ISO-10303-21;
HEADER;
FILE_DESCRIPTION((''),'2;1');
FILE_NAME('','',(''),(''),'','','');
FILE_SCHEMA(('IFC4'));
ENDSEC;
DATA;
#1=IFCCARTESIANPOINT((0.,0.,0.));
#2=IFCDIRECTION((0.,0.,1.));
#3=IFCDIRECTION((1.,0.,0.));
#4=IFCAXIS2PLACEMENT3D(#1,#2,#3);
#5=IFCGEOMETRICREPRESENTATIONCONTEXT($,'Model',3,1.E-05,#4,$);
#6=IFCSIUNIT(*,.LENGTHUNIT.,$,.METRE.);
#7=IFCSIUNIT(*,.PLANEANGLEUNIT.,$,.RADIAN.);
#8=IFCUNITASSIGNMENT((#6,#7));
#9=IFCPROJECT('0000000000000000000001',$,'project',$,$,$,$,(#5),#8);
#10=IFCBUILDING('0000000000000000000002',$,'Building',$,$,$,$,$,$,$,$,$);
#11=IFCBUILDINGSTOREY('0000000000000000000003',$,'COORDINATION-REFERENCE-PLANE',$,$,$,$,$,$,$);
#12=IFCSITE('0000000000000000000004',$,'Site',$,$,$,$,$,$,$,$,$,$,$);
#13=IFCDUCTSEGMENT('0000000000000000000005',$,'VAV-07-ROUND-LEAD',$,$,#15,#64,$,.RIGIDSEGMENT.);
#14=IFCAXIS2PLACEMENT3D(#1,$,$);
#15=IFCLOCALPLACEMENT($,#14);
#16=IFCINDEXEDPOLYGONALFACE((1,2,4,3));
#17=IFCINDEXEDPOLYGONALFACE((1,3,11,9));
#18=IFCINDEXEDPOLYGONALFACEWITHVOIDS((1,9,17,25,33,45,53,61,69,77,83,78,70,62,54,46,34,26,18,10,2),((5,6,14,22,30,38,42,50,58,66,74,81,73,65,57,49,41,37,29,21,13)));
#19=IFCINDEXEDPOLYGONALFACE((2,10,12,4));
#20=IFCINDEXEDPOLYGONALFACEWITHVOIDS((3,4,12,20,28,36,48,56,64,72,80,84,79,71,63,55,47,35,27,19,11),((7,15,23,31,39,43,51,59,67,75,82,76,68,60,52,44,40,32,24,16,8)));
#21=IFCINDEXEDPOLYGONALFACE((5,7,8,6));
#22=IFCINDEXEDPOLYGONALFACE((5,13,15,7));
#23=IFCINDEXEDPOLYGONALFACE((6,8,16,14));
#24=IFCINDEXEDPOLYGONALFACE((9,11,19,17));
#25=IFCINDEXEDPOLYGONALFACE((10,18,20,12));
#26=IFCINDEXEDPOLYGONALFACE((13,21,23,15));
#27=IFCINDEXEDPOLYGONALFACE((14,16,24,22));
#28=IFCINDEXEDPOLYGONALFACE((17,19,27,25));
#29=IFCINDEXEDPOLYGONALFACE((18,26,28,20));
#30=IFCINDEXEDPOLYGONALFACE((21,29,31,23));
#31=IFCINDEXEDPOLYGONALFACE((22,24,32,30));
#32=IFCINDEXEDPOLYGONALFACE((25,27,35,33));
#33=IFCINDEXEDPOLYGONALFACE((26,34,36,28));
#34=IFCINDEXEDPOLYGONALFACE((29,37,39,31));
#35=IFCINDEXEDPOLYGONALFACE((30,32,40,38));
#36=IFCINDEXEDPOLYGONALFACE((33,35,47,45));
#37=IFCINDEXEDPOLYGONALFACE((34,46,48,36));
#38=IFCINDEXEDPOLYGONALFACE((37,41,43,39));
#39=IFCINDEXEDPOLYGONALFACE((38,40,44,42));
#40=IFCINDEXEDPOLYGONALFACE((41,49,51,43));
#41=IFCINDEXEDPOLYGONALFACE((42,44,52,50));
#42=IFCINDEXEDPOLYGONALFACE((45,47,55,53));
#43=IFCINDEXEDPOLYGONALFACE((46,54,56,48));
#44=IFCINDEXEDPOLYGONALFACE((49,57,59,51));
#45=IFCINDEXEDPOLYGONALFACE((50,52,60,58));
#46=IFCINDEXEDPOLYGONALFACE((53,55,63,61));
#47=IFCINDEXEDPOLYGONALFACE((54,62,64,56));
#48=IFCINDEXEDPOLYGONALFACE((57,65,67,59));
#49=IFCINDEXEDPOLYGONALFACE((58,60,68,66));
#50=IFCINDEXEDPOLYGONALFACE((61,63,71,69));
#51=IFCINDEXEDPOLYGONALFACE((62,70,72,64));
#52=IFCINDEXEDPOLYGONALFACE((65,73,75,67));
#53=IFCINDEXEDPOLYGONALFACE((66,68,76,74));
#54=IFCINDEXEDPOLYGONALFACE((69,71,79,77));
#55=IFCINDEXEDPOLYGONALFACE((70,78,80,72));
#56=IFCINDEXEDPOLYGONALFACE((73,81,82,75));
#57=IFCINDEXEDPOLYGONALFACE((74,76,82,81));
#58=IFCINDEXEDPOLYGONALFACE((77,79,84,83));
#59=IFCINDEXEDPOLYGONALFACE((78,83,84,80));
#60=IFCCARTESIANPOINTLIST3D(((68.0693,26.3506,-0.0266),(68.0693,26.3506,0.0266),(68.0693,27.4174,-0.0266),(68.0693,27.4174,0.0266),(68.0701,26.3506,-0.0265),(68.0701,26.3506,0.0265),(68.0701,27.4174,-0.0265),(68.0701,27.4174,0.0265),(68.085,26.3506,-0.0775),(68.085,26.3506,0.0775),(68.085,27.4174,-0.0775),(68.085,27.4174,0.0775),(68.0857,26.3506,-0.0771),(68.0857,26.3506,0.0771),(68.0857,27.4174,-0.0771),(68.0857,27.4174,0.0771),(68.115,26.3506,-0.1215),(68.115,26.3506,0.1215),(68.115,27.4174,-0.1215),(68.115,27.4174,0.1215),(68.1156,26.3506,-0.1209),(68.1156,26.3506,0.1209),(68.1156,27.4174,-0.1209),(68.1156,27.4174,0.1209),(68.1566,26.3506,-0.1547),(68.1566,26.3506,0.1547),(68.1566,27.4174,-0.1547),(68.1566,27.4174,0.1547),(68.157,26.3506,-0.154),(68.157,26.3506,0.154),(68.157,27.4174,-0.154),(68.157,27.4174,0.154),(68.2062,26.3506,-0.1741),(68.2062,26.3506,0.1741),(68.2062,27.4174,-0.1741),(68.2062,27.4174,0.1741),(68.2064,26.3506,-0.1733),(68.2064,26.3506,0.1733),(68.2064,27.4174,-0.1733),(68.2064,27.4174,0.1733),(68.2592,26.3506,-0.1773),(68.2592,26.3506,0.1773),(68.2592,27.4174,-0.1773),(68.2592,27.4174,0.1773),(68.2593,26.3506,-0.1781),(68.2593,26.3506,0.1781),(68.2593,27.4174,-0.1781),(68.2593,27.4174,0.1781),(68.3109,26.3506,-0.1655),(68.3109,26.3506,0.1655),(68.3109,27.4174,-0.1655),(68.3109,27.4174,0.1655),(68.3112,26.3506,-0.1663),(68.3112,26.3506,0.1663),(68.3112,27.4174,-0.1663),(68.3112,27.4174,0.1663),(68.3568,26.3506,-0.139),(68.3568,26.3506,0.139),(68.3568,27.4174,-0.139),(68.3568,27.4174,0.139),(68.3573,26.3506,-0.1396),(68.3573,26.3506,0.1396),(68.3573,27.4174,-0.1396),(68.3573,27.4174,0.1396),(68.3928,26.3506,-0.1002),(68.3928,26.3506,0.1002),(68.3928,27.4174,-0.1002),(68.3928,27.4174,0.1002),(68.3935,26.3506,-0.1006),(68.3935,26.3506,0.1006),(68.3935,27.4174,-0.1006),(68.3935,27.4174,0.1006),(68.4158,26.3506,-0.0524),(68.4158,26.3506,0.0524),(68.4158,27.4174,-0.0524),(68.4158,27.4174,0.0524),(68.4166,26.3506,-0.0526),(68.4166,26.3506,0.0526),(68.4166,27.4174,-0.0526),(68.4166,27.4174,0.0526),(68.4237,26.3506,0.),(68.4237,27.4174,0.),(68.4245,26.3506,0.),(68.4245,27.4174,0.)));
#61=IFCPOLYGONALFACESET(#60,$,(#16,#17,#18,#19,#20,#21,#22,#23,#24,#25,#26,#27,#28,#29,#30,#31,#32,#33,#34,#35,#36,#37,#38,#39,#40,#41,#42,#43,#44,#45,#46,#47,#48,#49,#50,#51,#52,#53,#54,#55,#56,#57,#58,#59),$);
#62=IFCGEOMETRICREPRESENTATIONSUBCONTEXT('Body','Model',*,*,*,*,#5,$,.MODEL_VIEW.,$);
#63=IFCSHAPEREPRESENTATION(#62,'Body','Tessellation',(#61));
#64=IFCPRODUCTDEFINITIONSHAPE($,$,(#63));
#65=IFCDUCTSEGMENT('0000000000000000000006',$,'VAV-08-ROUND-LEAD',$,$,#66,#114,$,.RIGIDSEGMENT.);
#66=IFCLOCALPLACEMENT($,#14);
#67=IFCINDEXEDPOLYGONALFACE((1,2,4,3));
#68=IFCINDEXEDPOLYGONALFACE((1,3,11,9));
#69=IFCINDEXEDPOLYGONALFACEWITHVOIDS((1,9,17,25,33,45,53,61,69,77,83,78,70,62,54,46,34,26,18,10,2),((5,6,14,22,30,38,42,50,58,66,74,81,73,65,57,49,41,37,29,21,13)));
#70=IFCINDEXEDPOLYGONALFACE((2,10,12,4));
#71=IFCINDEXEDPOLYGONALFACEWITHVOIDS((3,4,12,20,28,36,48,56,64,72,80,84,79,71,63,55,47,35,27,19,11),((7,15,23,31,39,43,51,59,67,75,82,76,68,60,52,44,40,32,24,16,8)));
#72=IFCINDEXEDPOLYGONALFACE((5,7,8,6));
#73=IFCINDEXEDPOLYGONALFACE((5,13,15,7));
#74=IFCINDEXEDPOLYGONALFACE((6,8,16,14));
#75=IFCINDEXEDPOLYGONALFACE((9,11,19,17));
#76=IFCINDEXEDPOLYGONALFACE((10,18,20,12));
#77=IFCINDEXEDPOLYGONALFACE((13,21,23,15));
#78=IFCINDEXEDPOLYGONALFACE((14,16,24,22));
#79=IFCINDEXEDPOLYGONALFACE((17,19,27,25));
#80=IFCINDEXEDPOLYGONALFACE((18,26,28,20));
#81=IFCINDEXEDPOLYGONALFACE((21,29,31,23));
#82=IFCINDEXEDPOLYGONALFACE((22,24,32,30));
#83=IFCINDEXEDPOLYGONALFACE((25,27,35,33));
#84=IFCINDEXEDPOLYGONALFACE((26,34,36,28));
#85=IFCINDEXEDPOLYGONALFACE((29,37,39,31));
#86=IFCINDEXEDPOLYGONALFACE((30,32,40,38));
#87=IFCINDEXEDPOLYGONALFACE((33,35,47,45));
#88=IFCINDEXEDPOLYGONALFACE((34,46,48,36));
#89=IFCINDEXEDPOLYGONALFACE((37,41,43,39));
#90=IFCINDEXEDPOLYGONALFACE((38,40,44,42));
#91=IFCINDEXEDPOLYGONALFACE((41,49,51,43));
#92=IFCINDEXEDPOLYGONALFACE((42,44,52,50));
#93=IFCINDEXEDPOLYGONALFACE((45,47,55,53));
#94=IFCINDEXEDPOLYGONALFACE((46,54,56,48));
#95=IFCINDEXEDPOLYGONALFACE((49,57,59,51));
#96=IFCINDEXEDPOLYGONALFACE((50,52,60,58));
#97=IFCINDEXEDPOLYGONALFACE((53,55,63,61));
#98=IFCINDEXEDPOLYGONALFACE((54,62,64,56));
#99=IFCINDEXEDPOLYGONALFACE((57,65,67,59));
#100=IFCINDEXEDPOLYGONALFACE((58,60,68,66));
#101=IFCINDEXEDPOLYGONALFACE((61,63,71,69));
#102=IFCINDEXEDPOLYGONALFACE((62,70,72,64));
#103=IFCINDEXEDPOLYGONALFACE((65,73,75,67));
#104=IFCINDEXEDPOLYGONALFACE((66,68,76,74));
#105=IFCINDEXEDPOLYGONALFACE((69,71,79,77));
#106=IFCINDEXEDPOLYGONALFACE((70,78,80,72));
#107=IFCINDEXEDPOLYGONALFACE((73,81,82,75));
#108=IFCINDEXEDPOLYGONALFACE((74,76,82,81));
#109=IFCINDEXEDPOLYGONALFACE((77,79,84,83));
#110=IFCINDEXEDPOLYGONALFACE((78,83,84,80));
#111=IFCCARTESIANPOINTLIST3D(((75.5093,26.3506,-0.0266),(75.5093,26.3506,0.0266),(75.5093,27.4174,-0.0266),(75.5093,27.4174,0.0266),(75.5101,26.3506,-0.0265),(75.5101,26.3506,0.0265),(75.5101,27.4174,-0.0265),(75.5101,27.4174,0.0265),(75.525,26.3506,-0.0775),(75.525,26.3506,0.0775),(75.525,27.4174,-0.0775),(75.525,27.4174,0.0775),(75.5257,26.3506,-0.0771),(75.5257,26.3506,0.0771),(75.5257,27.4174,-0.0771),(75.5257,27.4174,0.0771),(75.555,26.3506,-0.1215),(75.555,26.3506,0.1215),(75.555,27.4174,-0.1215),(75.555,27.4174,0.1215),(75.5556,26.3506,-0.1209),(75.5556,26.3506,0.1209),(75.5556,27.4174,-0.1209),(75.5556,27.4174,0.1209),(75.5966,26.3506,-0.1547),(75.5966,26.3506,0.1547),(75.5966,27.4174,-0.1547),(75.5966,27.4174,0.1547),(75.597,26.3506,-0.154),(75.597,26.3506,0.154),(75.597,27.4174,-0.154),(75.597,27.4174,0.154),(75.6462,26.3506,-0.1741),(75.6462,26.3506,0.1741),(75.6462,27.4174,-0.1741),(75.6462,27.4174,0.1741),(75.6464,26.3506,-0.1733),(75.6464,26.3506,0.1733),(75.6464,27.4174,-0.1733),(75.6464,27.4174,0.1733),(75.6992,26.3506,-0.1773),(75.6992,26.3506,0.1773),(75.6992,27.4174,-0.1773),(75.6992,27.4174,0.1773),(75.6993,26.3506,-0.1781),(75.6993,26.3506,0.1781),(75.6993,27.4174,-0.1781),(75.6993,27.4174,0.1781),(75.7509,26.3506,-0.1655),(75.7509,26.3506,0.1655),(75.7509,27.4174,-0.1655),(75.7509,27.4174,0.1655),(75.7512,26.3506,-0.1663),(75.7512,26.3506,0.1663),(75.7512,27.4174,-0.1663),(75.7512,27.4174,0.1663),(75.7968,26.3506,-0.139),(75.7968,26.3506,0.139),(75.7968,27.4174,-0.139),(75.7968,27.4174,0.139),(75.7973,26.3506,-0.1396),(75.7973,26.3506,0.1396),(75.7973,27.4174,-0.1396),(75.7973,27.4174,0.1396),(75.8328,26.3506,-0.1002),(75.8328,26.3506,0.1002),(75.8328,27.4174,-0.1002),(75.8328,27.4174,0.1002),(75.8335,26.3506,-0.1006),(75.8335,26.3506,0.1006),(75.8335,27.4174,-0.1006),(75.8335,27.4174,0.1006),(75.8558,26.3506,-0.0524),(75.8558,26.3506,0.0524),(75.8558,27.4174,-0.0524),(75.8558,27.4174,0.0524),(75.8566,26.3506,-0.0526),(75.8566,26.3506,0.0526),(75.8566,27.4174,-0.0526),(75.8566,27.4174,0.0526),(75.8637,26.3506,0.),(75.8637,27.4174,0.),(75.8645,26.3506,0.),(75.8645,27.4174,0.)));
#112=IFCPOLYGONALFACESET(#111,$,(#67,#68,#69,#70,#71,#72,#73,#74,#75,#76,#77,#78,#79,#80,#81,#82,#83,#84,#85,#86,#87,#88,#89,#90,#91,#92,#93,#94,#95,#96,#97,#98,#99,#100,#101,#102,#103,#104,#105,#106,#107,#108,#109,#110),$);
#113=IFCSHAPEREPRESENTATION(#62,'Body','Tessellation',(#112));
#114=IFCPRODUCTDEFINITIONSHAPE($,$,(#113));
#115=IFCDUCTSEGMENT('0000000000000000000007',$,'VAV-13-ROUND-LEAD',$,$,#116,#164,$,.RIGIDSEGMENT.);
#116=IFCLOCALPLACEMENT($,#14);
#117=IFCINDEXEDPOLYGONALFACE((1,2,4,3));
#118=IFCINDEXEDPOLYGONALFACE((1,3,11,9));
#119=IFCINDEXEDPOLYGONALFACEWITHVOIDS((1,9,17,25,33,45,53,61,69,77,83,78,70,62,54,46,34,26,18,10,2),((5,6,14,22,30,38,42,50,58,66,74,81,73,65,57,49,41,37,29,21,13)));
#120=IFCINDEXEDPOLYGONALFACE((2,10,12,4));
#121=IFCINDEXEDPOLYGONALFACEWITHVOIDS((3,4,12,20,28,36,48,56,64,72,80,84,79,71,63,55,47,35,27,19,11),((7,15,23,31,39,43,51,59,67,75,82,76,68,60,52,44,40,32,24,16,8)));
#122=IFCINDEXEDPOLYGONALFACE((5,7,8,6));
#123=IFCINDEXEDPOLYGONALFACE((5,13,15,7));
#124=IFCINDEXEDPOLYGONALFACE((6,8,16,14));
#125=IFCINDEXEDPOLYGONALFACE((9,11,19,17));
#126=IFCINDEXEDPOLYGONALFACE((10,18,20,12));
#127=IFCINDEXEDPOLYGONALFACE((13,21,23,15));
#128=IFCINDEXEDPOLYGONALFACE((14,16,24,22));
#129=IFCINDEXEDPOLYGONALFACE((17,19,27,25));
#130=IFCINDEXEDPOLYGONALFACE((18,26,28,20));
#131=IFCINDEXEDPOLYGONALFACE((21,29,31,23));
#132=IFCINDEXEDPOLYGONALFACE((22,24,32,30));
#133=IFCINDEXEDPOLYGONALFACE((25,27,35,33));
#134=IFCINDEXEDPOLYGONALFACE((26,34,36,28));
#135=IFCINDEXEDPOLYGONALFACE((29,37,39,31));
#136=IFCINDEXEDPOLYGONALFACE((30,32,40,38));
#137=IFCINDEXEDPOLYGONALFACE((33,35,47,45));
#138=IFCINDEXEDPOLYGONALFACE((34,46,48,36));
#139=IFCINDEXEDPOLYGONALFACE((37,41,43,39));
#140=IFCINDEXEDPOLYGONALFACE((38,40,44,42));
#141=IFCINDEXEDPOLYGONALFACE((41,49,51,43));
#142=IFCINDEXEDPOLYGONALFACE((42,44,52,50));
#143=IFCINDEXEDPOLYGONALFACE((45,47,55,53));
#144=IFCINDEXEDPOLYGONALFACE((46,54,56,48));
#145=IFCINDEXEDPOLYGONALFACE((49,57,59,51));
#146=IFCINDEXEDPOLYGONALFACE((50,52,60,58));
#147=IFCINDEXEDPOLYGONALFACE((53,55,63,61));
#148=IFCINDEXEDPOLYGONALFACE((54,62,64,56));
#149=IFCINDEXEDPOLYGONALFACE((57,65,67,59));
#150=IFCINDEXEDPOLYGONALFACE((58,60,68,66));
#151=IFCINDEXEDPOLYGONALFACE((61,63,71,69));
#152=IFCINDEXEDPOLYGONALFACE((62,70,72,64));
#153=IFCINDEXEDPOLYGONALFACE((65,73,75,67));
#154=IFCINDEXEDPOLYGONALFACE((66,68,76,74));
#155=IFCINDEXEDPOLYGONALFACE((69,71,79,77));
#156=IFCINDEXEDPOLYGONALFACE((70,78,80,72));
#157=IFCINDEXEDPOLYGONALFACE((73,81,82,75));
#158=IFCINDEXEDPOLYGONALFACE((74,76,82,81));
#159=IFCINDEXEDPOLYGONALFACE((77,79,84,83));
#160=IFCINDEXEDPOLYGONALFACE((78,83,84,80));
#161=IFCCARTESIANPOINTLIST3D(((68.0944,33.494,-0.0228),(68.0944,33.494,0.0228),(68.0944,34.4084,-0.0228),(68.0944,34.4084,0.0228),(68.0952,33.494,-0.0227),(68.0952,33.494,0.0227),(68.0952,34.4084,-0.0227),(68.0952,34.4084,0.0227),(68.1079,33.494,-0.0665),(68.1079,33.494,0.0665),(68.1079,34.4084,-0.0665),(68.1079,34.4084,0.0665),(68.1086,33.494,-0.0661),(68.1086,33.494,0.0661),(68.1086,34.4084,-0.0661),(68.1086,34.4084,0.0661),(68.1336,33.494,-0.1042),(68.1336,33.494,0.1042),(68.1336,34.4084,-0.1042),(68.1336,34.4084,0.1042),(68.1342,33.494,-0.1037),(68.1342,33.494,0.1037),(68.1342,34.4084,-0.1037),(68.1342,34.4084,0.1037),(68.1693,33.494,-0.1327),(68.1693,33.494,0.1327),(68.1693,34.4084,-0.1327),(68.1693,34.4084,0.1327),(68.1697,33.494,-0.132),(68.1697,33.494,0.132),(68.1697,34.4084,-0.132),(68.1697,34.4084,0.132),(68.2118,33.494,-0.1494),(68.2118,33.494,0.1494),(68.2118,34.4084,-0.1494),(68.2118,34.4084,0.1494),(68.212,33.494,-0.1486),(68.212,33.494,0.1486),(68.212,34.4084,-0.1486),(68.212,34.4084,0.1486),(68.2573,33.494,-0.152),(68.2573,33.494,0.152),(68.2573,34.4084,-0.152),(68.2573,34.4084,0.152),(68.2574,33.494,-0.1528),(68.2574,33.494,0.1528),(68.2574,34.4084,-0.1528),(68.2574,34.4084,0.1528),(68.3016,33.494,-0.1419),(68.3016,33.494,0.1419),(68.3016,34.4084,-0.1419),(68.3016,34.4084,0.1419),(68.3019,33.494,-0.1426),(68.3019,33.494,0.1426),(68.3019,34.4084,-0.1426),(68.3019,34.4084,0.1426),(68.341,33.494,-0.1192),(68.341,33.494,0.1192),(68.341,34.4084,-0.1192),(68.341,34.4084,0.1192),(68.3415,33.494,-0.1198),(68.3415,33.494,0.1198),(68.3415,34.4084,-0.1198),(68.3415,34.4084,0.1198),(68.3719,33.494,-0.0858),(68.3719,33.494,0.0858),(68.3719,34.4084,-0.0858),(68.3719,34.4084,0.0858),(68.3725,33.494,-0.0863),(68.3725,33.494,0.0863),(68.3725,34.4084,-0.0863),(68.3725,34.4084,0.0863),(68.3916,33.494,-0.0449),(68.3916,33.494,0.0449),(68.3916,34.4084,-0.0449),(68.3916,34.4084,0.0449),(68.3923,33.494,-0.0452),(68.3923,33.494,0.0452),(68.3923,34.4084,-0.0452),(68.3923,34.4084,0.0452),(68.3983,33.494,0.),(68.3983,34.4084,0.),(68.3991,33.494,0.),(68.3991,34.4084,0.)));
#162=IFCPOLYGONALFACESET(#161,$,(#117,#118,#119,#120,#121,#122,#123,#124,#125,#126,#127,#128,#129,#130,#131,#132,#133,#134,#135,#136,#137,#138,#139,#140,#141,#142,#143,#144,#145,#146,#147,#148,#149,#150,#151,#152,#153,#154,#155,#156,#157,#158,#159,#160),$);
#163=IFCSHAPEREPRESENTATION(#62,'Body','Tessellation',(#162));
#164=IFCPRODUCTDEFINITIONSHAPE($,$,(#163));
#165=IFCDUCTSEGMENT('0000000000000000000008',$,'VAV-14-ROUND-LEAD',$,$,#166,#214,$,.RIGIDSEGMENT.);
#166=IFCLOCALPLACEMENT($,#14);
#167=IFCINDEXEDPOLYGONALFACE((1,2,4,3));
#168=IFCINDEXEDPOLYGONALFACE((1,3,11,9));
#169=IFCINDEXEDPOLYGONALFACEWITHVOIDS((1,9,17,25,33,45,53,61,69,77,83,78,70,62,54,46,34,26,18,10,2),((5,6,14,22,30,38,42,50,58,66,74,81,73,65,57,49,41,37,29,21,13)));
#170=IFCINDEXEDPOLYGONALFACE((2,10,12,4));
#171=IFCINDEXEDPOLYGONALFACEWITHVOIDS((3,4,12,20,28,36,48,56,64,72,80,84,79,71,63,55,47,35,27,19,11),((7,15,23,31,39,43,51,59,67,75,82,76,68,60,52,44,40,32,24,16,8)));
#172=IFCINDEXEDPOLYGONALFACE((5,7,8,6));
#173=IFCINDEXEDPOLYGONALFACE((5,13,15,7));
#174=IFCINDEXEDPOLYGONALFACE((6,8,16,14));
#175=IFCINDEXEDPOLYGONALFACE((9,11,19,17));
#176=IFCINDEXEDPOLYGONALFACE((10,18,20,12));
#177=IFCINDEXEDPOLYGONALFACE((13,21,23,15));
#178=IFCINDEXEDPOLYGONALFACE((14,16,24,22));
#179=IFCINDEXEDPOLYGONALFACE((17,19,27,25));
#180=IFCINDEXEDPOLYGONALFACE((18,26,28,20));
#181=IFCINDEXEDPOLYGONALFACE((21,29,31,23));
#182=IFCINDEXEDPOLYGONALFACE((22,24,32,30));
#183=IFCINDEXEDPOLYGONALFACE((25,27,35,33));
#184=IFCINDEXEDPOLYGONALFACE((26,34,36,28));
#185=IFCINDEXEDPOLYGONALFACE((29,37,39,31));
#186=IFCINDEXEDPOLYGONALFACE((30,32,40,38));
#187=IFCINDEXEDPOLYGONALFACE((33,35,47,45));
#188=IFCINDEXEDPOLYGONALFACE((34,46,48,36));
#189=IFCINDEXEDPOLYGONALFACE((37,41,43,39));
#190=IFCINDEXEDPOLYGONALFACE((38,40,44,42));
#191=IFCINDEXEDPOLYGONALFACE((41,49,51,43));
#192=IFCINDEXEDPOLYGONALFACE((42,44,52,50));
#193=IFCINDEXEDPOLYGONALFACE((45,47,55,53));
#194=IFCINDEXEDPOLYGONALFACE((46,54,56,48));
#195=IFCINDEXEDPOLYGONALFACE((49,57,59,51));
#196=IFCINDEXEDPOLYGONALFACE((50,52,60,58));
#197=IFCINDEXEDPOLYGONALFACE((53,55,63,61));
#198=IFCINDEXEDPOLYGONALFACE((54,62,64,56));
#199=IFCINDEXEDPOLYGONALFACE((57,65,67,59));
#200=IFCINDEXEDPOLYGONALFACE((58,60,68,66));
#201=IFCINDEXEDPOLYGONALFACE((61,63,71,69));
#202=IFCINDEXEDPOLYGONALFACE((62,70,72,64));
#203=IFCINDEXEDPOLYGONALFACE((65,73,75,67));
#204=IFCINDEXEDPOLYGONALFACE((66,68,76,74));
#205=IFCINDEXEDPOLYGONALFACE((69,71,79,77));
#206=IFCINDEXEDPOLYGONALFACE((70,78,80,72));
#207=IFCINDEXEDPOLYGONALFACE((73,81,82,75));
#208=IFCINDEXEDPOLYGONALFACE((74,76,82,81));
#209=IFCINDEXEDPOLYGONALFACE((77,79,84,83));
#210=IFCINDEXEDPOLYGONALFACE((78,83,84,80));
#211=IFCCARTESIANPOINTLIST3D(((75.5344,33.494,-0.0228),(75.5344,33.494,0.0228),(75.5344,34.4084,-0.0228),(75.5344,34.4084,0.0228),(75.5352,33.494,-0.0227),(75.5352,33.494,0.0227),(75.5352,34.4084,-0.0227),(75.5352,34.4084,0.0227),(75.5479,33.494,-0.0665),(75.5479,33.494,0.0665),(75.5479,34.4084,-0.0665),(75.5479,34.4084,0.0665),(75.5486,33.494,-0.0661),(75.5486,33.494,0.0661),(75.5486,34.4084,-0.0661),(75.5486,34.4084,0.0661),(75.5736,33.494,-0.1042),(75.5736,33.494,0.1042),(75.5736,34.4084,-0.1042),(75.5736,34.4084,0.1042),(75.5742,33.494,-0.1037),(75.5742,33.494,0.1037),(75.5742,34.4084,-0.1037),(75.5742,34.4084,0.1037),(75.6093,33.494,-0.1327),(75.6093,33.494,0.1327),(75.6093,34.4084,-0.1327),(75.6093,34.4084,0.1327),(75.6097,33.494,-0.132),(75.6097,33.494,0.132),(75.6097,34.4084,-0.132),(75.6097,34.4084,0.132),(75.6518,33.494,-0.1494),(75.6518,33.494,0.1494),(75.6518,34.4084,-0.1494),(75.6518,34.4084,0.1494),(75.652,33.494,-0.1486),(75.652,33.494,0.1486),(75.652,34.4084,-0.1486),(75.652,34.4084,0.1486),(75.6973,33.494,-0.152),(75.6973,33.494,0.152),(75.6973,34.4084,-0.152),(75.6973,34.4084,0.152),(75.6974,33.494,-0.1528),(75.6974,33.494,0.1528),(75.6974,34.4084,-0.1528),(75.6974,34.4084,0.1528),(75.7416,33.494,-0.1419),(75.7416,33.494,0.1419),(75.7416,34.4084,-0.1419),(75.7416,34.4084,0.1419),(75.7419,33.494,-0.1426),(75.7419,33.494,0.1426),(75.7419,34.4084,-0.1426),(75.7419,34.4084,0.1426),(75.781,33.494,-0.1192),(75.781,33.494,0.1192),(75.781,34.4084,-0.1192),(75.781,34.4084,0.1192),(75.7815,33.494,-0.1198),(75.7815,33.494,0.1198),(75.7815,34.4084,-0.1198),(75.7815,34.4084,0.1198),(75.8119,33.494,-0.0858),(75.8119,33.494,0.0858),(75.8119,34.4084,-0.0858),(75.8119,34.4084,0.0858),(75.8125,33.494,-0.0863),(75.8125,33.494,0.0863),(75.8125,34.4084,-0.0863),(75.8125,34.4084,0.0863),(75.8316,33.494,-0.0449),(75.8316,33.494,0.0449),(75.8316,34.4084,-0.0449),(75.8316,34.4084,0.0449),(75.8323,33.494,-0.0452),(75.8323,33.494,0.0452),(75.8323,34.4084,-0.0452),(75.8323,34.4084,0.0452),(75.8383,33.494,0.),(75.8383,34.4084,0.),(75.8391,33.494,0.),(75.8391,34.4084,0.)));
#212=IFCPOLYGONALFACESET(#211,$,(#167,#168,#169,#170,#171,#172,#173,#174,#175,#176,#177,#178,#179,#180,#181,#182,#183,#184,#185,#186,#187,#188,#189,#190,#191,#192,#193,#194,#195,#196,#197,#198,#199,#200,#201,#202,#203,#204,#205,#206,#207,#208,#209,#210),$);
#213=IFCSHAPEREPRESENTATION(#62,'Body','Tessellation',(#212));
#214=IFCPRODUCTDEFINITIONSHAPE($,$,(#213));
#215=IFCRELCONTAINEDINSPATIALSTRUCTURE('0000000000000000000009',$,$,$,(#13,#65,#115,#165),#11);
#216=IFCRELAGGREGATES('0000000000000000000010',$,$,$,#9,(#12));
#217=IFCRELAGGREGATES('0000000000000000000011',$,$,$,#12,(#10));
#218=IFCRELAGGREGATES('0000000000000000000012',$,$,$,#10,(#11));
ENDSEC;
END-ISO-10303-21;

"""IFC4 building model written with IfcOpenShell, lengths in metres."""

from ifc_helpers import new_model, si_unit, frame, origin, origin_with_axes, place, context, subcontext, project, spatial, hollow_circle, extrude, element, save


model = new_model("IFC4")

# Units and contexts
model_context = context("Model", 3, precision=1e-05, world=origin_with_axes())
body_context_1 = subcontext(model_context, "Body", "Model", "MODEL_VIEW")
ifc_project = project(units=[si_unit("LENGTHUNIT", "METRE"), si_unit("PLANEANGLEUNIT", "RADIAN")], contexts=[model_context])

# Site, building, storey
site = spatial("IfcSite", under=ifc_project, Name="Site")
building = spatial("IfcBuilding", under=site, Name="Building")
storey = spatial("IfcBuildingStorey", under=building, Name="COORDINATION-REFERENCE-PLANE")

# Duct segments
for number, where, z_axis, x_axis, name in (
    (1, (68.2459, 27.4174, 0.0), (0.0, -1.0, 0.0), (1.0, 0.0, 0.0), "VAV-07-ROUND-LEAD"),
    (2, (75.6859, 27.4174, 0.0), (0.0, -1.0, 0.0), (1.0, 0.0, 0.0), "VAV-08-ROUND-LEAD"),
):
    element("IfcDuctSegment", number, at=place(None, frame(where, z_axis=z_axis, x_axis=x_axis)), inside=storey, Name=name, PredefinedType="RIGIDSEGMENT", context=body_context_1, shape_type="SweptSolid", body=[
        extrude(hollow_circle(Radius=0.1786, WallThickness=0.0008), origin(), (0.0, 0.0, 1.0), 1.0668),
    ])
for number, where, z_axis, x_axis, name in (
    (3, (68.2459, 34.4084, 0.0), (0.0, -1.0, 0.0), (1.0, 0.0, 0.0), "VAV-13-ROUND-LEAD"),
    (4, (75.6859, 34.4084, 0.0), (0.0, -1.0, 0.0), (1.0, 0.0, 0.0), "VAV-14-ROUND-LEAD"),
):
    element("IfcDuctSegment", number, at=place(None, frame(where, z_axis=z_axis, x_axis=x_axis)), inside=storey, Name=name, PredefinedType="RIGIDSEGMENT", context=body_context_1, shape_type="SweptSolid", body=[
        extrude(hollow_circle(Radius=0.1532, WallThickness=0.0008), origin(), (0.0, 0.0, 1.0), 0.9144),
    ])

save(model, "model.ifc")
